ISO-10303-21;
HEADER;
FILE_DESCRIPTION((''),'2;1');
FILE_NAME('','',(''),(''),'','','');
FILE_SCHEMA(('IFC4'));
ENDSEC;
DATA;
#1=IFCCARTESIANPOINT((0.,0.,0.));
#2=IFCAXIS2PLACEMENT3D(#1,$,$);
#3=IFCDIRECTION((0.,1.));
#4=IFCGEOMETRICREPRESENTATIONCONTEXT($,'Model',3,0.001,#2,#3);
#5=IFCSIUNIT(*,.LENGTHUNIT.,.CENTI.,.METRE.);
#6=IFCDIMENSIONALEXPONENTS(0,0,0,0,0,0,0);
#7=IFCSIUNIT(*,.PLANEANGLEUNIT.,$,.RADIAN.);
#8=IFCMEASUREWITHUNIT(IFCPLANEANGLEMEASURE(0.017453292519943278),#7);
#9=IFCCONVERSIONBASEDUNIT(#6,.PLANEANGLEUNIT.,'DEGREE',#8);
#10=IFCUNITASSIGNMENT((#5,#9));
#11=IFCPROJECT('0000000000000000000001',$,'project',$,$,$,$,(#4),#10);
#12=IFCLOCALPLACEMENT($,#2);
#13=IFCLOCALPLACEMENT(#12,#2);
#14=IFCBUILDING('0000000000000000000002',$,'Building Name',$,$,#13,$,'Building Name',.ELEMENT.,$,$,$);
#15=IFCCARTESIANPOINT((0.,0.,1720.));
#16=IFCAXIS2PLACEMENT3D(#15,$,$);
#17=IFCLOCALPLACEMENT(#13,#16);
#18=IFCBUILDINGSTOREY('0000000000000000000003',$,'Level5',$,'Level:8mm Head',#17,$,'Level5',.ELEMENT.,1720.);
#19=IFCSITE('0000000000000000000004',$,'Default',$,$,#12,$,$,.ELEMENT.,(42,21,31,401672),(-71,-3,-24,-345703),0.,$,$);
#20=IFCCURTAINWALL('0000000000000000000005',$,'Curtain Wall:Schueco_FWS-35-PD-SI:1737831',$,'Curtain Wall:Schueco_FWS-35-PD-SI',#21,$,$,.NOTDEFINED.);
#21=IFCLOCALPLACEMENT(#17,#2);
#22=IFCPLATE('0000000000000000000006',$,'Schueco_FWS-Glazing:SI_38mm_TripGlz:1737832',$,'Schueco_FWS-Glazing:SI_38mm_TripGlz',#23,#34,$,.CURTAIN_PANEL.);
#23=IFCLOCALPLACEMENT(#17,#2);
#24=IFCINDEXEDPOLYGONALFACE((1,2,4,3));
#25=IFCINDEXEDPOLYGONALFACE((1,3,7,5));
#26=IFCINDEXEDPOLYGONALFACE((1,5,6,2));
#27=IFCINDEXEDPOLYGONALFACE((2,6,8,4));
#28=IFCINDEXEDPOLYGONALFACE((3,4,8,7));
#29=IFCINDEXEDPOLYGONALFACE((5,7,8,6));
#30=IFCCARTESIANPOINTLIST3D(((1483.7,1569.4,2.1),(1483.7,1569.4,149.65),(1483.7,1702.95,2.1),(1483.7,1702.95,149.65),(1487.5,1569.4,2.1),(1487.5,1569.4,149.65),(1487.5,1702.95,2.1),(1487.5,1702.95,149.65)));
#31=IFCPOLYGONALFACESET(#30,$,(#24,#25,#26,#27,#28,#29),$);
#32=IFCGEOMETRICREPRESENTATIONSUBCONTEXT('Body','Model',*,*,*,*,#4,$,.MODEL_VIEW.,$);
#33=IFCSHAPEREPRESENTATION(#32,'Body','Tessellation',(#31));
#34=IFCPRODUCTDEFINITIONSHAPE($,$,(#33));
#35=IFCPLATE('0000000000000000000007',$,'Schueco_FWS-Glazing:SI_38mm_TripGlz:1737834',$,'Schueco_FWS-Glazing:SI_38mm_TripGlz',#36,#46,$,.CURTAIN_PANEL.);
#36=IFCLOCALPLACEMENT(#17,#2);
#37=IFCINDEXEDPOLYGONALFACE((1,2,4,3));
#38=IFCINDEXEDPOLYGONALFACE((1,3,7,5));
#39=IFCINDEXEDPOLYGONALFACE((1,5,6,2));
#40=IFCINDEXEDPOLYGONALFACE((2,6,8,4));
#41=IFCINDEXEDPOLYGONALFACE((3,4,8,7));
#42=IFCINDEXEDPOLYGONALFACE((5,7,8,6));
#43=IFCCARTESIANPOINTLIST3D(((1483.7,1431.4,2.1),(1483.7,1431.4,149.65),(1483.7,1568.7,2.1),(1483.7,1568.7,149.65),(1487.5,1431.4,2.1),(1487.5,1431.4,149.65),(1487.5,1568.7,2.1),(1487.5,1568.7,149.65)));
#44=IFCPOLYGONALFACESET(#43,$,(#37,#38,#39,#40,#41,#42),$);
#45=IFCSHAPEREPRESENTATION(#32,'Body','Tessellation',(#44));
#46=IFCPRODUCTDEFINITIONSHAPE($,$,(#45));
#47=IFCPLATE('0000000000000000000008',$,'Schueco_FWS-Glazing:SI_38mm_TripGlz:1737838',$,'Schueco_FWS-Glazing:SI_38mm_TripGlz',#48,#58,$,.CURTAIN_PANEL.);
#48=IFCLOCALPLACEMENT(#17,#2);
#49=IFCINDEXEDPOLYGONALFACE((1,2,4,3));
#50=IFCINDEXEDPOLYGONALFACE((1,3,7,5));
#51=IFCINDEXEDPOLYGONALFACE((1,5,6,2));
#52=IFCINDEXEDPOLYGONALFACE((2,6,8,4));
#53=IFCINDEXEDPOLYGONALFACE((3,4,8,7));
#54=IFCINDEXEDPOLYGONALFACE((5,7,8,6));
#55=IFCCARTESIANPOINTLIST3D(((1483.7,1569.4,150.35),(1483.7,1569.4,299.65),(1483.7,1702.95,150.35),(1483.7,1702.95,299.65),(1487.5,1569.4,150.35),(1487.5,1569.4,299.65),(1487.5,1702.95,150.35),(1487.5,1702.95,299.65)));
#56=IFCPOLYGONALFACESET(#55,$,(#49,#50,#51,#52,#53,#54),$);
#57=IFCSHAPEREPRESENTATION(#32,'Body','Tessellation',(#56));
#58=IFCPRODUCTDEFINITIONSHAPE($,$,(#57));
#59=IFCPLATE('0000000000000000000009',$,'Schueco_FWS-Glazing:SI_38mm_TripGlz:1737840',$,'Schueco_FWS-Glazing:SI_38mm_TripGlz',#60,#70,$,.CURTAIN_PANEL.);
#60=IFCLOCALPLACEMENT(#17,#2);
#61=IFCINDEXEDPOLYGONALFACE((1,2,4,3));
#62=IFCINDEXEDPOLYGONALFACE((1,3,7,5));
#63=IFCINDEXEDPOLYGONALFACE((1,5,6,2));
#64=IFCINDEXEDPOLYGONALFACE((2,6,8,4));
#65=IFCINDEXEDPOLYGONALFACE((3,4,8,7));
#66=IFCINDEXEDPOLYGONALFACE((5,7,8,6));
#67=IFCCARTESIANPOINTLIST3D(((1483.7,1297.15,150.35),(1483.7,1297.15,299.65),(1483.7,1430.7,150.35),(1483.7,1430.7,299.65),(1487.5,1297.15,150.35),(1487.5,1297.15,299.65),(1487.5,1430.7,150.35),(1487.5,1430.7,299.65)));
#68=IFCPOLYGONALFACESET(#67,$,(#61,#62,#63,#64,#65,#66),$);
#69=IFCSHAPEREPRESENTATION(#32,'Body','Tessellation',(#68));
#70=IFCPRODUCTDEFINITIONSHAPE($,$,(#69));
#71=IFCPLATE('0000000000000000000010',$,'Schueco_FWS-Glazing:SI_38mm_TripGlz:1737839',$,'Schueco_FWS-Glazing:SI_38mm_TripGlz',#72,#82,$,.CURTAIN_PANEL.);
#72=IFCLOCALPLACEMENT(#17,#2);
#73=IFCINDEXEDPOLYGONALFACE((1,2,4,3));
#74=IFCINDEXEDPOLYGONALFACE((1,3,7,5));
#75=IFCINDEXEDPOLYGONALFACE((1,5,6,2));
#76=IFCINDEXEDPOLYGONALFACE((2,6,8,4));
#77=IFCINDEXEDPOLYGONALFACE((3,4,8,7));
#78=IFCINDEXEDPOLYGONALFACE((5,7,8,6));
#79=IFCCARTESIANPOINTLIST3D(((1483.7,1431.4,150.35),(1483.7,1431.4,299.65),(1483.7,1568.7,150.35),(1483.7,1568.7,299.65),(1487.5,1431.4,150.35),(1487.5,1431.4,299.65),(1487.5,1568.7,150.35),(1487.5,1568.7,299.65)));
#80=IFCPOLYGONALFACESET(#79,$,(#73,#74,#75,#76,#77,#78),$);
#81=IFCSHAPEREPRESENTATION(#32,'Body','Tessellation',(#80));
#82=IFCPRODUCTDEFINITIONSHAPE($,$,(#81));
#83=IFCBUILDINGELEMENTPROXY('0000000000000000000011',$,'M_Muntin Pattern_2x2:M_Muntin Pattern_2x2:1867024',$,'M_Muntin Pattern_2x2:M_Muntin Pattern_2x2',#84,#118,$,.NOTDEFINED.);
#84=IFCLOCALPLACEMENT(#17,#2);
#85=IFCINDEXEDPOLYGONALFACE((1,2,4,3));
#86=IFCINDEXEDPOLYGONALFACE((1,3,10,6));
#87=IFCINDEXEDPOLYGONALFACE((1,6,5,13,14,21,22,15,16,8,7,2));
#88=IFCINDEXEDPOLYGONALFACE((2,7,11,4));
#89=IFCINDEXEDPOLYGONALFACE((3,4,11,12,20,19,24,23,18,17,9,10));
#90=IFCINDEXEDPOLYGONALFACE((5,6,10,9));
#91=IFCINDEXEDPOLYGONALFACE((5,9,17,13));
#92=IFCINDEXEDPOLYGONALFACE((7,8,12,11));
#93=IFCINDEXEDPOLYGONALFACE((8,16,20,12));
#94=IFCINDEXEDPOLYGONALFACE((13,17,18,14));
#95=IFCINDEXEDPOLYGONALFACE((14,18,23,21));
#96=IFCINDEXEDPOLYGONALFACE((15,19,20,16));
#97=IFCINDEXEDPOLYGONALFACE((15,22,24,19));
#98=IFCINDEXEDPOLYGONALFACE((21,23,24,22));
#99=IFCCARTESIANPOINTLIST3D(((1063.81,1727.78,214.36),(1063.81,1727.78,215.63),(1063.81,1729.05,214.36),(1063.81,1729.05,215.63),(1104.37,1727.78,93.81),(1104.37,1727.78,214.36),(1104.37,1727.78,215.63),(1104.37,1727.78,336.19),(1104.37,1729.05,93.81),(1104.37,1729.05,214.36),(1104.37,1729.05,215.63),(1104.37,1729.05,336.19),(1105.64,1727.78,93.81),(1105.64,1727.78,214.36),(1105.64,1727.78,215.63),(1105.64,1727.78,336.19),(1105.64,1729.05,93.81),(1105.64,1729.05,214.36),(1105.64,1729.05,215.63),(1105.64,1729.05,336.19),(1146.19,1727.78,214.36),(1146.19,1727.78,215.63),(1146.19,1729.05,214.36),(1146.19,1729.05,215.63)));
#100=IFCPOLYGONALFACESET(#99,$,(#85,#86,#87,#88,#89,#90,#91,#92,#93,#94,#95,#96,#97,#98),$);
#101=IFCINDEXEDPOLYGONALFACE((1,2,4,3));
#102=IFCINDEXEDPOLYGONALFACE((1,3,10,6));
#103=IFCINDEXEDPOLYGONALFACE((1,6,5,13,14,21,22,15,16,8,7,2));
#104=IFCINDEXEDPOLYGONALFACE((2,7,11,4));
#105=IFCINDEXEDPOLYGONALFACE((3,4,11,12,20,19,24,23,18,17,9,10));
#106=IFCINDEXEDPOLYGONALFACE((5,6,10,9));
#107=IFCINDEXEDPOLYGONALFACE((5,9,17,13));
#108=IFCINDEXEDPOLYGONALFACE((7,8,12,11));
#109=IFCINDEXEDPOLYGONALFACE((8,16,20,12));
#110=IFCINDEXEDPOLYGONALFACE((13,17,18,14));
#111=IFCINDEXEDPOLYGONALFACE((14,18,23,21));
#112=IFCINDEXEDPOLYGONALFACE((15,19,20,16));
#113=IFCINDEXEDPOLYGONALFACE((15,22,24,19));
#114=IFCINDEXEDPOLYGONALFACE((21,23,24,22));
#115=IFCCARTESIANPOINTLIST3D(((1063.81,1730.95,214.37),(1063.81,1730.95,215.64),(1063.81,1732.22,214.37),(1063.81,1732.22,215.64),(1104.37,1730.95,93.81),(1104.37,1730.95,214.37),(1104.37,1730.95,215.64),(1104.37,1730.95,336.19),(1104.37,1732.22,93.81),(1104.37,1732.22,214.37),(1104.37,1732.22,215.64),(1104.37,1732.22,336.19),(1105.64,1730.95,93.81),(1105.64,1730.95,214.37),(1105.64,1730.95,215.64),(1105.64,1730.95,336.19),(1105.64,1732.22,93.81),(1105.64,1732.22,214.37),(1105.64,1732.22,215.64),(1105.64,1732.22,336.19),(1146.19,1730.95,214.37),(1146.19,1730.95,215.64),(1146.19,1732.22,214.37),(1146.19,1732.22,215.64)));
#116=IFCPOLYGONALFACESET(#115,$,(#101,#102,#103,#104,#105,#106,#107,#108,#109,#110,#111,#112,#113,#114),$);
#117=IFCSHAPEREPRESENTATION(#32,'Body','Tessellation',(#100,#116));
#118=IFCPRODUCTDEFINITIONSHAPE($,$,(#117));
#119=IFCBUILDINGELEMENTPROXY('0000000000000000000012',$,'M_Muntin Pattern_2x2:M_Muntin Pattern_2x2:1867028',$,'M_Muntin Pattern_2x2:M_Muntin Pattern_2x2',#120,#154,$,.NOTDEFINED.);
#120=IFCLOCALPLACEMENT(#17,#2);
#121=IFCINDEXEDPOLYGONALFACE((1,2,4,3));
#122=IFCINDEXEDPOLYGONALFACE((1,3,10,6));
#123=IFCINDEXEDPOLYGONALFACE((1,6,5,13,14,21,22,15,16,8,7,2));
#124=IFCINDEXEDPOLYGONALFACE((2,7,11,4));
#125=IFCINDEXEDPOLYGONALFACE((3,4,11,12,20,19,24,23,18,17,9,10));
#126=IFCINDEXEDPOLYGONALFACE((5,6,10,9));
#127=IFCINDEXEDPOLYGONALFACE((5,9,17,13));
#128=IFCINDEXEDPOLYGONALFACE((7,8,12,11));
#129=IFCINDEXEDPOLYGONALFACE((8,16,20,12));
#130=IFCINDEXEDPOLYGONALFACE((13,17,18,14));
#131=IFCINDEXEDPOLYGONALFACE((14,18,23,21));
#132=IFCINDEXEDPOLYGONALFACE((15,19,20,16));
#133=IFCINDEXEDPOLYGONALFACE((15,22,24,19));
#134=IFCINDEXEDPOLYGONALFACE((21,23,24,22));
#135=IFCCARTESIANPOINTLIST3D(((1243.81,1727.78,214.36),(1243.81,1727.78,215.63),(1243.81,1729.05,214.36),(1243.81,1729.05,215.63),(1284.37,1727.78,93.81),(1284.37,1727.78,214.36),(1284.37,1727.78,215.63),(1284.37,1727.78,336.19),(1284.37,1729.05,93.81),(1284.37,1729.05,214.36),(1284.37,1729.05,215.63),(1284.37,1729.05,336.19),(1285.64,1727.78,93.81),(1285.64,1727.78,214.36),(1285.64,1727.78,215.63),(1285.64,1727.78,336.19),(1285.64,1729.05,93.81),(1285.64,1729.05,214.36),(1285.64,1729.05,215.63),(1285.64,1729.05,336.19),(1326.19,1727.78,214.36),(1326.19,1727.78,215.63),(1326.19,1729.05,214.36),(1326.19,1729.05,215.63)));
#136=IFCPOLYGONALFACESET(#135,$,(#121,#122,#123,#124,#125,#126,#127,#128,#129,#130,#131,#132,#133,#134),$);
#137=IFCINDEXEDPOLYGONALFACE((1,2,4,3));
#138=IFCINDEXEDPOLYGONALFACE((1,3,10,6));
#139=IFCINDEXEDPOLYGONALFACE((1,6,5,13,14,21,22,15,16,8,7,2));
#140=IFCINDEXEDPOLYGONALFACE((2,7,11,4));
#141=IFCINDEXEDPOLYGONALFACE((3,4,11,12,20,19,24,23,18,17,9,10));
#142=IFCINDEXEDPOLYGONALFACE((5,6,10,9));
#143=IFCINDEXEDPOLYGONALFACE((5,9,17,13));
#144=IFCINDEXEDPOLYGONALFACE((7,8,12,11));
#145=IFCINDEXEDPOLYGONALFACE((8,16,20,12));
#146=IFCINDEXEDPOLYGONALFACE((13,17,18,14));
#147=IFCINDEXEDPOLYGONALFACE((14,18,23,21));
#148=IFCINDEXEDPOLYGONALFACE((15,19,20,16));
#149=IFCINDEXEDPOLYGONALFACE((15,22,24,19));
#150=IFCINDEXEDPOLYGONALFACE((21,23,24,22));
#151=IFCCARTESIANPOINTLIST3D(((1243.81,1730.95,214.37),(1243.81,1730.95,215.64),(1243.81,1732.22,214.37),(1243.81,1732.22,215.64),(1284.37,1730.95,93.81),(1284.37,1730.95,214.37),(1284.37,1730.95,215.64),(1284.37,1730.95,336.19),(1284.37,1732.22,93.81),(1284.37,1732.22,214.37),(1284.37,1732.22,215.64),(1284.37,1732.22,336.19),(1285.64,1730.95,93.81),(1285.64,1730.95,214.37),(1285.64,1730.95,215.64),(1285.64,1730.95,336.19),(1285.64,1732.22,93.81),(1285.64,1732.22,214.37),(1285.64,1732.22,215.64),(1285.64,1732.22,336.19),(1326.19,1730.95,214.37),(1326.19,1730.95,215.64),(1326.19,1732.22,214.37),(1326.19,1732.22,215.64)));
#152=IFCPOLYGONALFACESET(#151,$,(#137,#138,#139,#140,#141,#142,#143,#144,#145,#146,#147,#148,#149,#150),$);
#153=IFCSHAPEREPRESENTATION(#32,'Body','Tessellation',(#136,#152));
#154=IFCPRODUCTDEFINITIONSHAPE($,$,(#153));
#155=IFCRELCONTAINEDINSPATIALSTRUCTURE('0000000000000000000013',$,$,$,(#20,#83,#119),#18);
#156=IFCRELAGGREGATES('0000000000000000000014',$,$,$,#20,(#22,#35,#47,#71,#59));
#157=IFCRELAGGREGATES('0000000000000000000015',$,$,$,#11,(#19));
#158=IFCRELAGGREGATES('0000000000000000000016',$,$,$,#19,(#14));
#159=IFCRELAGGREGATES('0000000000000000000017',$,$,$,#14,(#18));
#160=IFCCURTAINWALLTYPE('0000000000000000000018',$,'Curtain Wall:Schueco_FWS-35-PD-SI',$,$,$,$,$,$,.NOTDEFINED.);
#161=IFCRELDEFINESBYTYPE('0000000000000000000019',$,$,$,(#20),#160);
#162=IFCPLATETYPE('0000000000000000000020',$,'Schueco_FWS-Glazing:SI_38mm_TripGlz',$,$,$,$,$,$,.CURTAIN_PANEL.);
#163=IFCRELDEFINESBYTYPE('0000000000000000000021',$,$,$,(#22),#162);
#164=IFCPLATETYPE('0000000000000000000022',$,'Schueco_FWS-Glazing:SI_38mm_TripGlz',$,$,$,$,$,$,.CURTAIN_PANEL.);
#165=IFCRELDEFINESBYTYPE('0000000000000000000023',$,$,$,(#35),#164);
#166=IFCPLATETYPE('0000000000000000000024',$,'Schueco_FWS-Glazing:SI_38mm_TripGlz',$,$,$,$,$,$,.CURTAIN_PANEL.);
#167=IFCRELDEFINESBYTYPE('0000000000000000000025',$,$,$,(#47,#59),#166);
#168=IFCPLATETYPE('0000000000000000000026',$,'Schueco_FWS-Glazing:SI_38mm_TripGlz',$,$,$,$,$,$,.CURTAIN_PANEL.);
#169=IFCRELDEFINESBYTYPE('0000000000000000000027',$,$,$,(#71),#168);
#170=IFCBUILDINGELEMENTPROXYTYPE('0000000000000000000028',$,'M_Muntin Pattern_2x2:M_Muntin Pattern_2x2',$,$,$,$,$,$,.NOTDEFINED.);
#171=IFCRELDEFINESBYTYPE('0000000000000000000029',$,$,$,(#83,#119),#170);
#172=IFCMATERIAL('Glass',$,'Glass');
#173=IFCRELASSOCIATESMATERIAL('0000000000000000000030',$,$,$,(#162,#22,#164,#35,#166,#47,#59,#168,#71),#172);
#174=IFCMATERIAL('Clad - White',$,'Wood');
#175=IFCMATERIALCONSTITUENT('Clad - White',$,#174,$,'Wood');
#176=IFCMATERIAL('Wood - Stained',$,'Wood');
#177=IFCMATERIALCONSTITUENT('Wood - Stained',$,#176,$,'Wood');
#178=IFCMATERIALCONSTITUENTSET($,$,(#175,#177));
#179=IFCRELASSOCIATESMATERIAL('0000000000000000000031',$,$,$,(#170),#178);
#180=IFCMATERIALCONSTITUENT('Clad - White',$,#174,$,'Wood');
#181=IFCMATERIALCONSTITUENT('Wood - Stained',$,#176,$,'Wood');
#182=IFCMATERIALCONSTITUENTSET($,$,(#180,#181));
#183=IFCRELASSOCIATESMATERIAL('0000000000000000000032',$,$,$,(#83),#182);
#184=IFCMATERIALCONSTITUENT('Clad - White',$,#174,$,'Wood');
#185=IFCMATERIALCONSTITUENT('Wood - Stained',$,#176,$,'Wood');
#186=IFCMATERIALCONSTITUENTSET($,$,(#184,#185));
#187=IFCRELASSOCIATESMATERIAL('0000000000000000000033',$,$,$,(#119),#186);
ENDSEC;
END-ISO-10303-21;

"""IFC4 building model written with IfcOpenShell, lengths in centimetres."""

from ifc_helpers import new_model, entity, si_unit, converted_unit, direction, frame, origin, place, context, subcontext, project, spatial, indexed_curve, outline, extrude, source, transform, mapped, material, constituent, constituent_set, type_object, type_shapes, element, aggregate, save


model = new_model("IFC4")

# Units and contexts
model_context = context("Model", 3, precision=0.001, world=origin(), true_north=direction((0.0, 1.0)))
body_context = subcontext(model_context, "Body", "Model", "MODEL_VIEW")
ifc_project = project(units=[si_unit("LENGTHUNIT", "METRE", prefix="CENTI"), converted_unit("PLANEANGLEUNIT", "DEGREE", entity("IfcPlaneAngleMeasure", 0.017453292519943278), si_unit("PLANEANGLEUNIT", "RADIAN"), dimensions=[0, 0, 0, 0, 0, 0, 0])], contexts=[model_context])

# Site, building, storey
site_placement = place(None, origin())
site = spatial("IfcSite", under=ifc_project, at=site_placement, Name="Default", CompositionType="ELEMENT", RefLatitude=(42, 21, 31, 401672), RefLongitude=(-71, -3, -24, -345703), RefElevation=0.0)
building_placement = place(site_placement, origin())
building = spatial("IfcBuilding", under=site, at=building_placement, Name="Building Name", LongName="Building Name", CompositionType="ELEMENT")
storey_placement = place(building_placement, frame((0.0, 0.0, 1720.0)))
storey = spatial("IfcBuildingStorey", under=building, at=storey_placement, Name="Level5", ObjectType="Level:8mm Head", LongName="Level5", CompositionType="ELEMENT", Elevation=1720.0)

# Curtain wall, plates
curtain_wall_type = type_object("IfcCurtainWallType", Name="Curtain Wall:Schueco_FWS-35-PD-SI", PredefinedType="NOTDEFINED")
curtain_wall_placement = place(storey_placement, frame((0.0, 0.0, -1720.0)))
curtain_wall = element("IfcCurtainWall", 1, at=curtain_wall_placement, inside=storey, type_object=curtain_wall_type, Name="Curtain Wall:Schueco_FWS-35-PD-SI:1737831", ObjectType="Curtain Wall:Schueco_FWS-35-PD-SI", PredefinedType="NOTDEFINED")
ifc_material_1 = material(Name="Glass", Category="Glass")
plate_type_1 = type_object("IfcPlateType", Name="Schueco_FWS-Glazing:SI_38mm_TripGlz", PredefinedType="CURTAIN_PANEL", material=ifc_material_1)
shared_shape_1 = source(origin(), body_context, "Body", "SweptSolid", [
    extrude(outline(indexed_curve([(-1.9, -66.78), (1.9, -66.78), (1.9, 66.78), (-1.9, 66.78), (-1.9, -66.78)], self_intersect=False)), frame((0.0, -1.9, 0.0), z_axis=(0.0, 0.0, 1.0), x_axis=(0.0, 1.0, 0.0)), (0.0, 0.0, 1.0), 147.55),
])
type_shapes(plate_type_1, [shared_shape_1])
plate_1_placement = place(curtain_wall_placement, frame((1487.5, 1636.17, 1722.1), z_axis=(0.0, 0.0, 1.0), x_axis=(0.0, -1.0, 0.0)))
plate_1 = element("IfcPlate", 2, at=plate_1_placement, type_object=plate_type_1, material=ifc_material_1, Name="Schueco_FWS-Glazing:SI_38mm_TripGlz:1737832", ObjectType="Schueco_FWS-Glazing:SI_38mm_TripGlz", PredefinedType="CURTAIN_PANEL", context=body_context, shape_type="MappedRepresentation", body=[
    mapped(shared_shape_1, transform((0.0, 0.0, 0.0), scale=1.0)),
])
plate_type_2 = type_object("IfcPlateType", Name="Schueco_FWS-Glazing:SI_38mm_TripGlz", PredefinedType="CURTAIN_PANEL", material=ifc_material_1)
shared_shape_2 = source(origin(), body_context, "Body", "SweptSolid", [
    extrude(outline(indexed_curve([(-1.9, -68.65), (1.9, -68.65), (1.9, 68.65), (-1.9, 68.65), (-1.9, -68.65)], self_intersect=False)), frame((0.0, -1.9, 0.0), z_axis=(0.0, 0.0, 1.0), x_axis=(0.0, 1.0, 0.0)), (0.0, 0.0, 1.0), 147.55),
])
type_shapes(plate_type_2, [shared_shape_2])
plate_2_placement = place(curtain_wall_placement, frame((1487.5, 1500.05, 1722.1), z_axis=(0.0, 0.0, 1.0), x_axis=(0.0, -1.0, 0.0)))
plate_2 = element("IfcPlate", 3, at=plate_2_placement, type_object=plate_type_2, material=ifc_material_1, Name="Schueco_FWS-Glazing:SI_38mm_TripGlz:1737834", ObjectType="Schueco_FWS-Glazing:SI_38mm_TripGlz", PredefinedType="CURTAIN_PANEL", context=body_context, shape_type="MappedRepresentation", body=[
    mapped(shared_shape_2, transform((0.0, 0.0, 0.0), scale=1.0)),
])
plate_type_3 = type_object("IfcPlateType", Name="Schueco_FWS-Glazing:SI_38mm_TripGlz", PredefinedType="CURTAIN_PANEL", material=ifc_material_1)
shared_shape_3 = source(origin(), body_context, "Body", "SweptSolid", [
    extrude(outline(indexed_curve([(-1.9, -66.78), (1.9, -66.78), (1.9, 66.78), (-1.9, 66.78), (-1.9, -66.78)], self_intersect=False)), frame((0.0, -1.9, 0.0), z_axis=(0.0, 0.0, 1.0), x_axis=(0.0, 1.0, 0.0)), (0.0, 0.0, 1.0), 149.3),
])
type_shapes(plate_type_3, [shared_shape_3])
plate_3_placement = place(curtain_wall_placement, frame((1487.5, 1636.17, 1870.35), z_axis=(0.0, 0.0, 1.0), x_axis=(0.0, -1.0, 0.0)))
plate_3 = element("IfcPlate", 4, at=plate_3_placement, type_object=plate_type_3, material=ifc_material_1, Name="Schueco_FWS-Glazing:SI_38mm_TripGlz:1737838", ObjectType="Schueco_FWS-Glazing:SI_38mm_TripGlz", PredefinedType="CURTAIN_PANEL", context=body_context, shape_type="MappedRepresentation", body=[
    mapped(shared_shape_3, transform((0.0, 0.0, 0.0), scale=1.0)),
])
plate_4_placement = place(curtain_wall_placement, frame((1487.5, 1363.92, 1870.35), z_axis=(0.0, 0.0, 1.0), x_axis=(0.0, -1.0, 0.0)))
plate_4 = element("IfcPlate", 5, at=plate_4_placement, type_object=plate_type_3, material=ifc_material_1, Name="Schueco_FWS-Glazing:SI_38mm_TripGlz:1737840", ObjectType="Schueco_FWS-Glazing:SI_38mm_TripGlz", PredefinedType="CURTAIN_PANEL", context=body_context, shape_type="MappedRepresentation", body=[
    mapped(shared_shape_3, transform((0.0, 0.0, 0.0), scale=1.0)),
])
plate_type_4 = type_object("IfcPlateType", Name="Schueco_FWS-Glazing:SI_38mm_TripGlz", PredefinedType="CURTAIN_PANEL", material=ifc_material_1)
shared_shape_4 = source(origin(), body_context, "Body", "SweptSolid", [
    extrude(outline(indexed_curve([(-1.9, -68.65), (1.9, -68.65), (1.9, 68.65), (-1.9, 68.65), (-1.9, -68.65)], self_intersect=False)), frame((0.0, -1.9, 0.0), z_axis=(0.0, 0.0, 1.0), x_axis=(0.0, 1.0, 0.0)), (0.0, 0.0, 1.0), 149.3),
])
type_shapes(plate_type_4, [shared_shape_4])
plate_5_placement = place(curtain_wall_placement, frame((1487.5, 1500.05, 1870.35), z_axis=(0.0, 0.0, 1.0), x_axis=(0.0, -1.0, 0.0)))
plate_5 = element("IfcPlate", 6, at=plate_5_placement, type_object=plate_type_4, material=ifc_material_1, Name="Schueco_FWS-Glazing:SI_38mm_TripGlz:1737839", ObjectType="Schueco_FWS-Glazing:SI_38mm_TripGlz", PredefinedType="CURTAIN_PANEL", context=body_context, shape_type="MappedRepresentation", body=[
    mapped(shared_shape_4, transform((0.0, 0.0, 0.0), scale=1.0)),
])
aggregate(curtain_wall, [plate_1, plate_2, plate_3, plate_5, plate_4])

# Building element proxies
ifc_material_2 = material(Name="Clad - White", Category="Wood")
ifc_constituent_1 = constituent(ifc_material_2, Name="Clad - White", Category="Wood")
ifc_material_3 = material(Name="Wood - Stained", Category="Wood")
ifc_constituent_2 = constituent(ifc_material_3, Name="Wood - Stained", Category="Wood")
ifc_constituent_set_1 = constituent_set(constituents=[ifc_constituent_1, ifc_constituent_2])
ifc_constituent_3 = constituent(ifc_material_2, Name="Clad - White", Category="Wood")
ifc_constituent_4 = constituent(ifc_material_3, Name="Wood - Stained", Category="Wood")
ifc_constituent_set_2 = constituent_set(constituents=[ifc_constituent_3, ifc_constituent_4])
building_element_proxy_type_1 = type_object("IfcBuildingElementProxyType", Name="M_Muntin Pattern_2x2:M_Muntin Pattern_2x2", PredefinedType="NOTDEFINED", material=ifc_constituent_set_2)
shared_shape_5 = source(origin(), body_context, "Body", "SweptSolid", [
    extrude(outline(indexed_curve([(0.64, -0.64), (121.19, -0.64), (121.19, 0.63), (0.64, 0.63), (0.64, 41.19), (-0.63, 41.19), (-0.63, 0.63), (-121.19, 0.63), (-121.19, -0.64), (-0.63, -0.64), (-0.63, -41.19), (0.64, -41.19), (0.64, -0.64)], self_intersect=False)), frame((0.0, 0.95, 121.19), z_axis=(0.0, 1.0, 0.0), x_axis=(0.0, 0.0, 1.0)), (0.0, 0.0, 1.0), 1.27),
    extrude(outline(indexed_curve([(0.64, -0.64), (121.19, -0.64), (121.19, 0.63), (0.64, 0.63), (0.64, 41.19), (-0.63, 41.19), (-0.63, 0.63), (-121.19, 0.63), (-121.19, -0.64), (-0.63, -0.64), (-0.63, -41.19), (0.64, -41.19), (0.64, -0.64)], self_intersect=False)), frame((0.0, -2.22, 121.19), z_axis=(0.0, 1.0, 0.0), x_axis=(0.0, 0.0, 1.0)), (0.0, 0.0, 1.0), 1.27),
])
type_shapes(building_element_proxy_type_1, [shared_shape_5])
proxy_1_placement = place(storey_placement, frame((1105.0, 1730.0, 93.81), z_axis=(0.0, 0.0, 1.0), x_axis=(-1.0, 0.0, 0.0)))
element("IfcBuildingElementProxy", 7, at=proxy_1_placement, inside=storey, type_object=building_element_proxy_type_1, material=ifc_constituent_set_1, Name="M_Muntin Pattern_2x2:M_Muntin Pattern_2x2:1867024", ObjectType="M_Muntin Pattern_2x2:M_Muntin Pattern_2x2", PredefinedType="NOTDEFINED", context=body_context, shape_type="MappedRepresentation", body=[
    mapped(shared_shape_5, transform((0.0, 0.0, 0.0), scale=1.0)),
])
ifc_constituent_5 = constituent(ifc_material_2, Name="Clad - White", Category="Wood")
ifc_constituent_6 = constituent(ifc_material_3, Name="Wood - Stained", Category="Wood")
ifc_constituent_set_3 = constituent_set(constituents=[ifc_constituent_5, ifc_constituent_6])
proxy_2_placement = place(storey_placement, frame((1285.0, 1730.0, 93.81), z_axis=(0.0, 0.0, 1.0), x_axis=(-1.0, 0.0, 0.0)))
element("IfcBuildingElementProxy", 8, at=proxy_2_placement, inside=storey, type_object=building_element_proxy_type_1, material=ifc_constituent_set_3, Name="M_Muntin Pattern_2x2:M_Muntin Pattern_2x2:1867028", ObjectType="M_Muntin Pattern_2x2:M_Muntin Pattern_2x2", PredefinedType="NOTDEFINED", context=body_context, shape_type="MappedRepresentation", body=[
    mapped(shared_shape_5, transform((0.0, 0.0, 0.0), scale=1.0)),
])

save(model, "model.ifc")
